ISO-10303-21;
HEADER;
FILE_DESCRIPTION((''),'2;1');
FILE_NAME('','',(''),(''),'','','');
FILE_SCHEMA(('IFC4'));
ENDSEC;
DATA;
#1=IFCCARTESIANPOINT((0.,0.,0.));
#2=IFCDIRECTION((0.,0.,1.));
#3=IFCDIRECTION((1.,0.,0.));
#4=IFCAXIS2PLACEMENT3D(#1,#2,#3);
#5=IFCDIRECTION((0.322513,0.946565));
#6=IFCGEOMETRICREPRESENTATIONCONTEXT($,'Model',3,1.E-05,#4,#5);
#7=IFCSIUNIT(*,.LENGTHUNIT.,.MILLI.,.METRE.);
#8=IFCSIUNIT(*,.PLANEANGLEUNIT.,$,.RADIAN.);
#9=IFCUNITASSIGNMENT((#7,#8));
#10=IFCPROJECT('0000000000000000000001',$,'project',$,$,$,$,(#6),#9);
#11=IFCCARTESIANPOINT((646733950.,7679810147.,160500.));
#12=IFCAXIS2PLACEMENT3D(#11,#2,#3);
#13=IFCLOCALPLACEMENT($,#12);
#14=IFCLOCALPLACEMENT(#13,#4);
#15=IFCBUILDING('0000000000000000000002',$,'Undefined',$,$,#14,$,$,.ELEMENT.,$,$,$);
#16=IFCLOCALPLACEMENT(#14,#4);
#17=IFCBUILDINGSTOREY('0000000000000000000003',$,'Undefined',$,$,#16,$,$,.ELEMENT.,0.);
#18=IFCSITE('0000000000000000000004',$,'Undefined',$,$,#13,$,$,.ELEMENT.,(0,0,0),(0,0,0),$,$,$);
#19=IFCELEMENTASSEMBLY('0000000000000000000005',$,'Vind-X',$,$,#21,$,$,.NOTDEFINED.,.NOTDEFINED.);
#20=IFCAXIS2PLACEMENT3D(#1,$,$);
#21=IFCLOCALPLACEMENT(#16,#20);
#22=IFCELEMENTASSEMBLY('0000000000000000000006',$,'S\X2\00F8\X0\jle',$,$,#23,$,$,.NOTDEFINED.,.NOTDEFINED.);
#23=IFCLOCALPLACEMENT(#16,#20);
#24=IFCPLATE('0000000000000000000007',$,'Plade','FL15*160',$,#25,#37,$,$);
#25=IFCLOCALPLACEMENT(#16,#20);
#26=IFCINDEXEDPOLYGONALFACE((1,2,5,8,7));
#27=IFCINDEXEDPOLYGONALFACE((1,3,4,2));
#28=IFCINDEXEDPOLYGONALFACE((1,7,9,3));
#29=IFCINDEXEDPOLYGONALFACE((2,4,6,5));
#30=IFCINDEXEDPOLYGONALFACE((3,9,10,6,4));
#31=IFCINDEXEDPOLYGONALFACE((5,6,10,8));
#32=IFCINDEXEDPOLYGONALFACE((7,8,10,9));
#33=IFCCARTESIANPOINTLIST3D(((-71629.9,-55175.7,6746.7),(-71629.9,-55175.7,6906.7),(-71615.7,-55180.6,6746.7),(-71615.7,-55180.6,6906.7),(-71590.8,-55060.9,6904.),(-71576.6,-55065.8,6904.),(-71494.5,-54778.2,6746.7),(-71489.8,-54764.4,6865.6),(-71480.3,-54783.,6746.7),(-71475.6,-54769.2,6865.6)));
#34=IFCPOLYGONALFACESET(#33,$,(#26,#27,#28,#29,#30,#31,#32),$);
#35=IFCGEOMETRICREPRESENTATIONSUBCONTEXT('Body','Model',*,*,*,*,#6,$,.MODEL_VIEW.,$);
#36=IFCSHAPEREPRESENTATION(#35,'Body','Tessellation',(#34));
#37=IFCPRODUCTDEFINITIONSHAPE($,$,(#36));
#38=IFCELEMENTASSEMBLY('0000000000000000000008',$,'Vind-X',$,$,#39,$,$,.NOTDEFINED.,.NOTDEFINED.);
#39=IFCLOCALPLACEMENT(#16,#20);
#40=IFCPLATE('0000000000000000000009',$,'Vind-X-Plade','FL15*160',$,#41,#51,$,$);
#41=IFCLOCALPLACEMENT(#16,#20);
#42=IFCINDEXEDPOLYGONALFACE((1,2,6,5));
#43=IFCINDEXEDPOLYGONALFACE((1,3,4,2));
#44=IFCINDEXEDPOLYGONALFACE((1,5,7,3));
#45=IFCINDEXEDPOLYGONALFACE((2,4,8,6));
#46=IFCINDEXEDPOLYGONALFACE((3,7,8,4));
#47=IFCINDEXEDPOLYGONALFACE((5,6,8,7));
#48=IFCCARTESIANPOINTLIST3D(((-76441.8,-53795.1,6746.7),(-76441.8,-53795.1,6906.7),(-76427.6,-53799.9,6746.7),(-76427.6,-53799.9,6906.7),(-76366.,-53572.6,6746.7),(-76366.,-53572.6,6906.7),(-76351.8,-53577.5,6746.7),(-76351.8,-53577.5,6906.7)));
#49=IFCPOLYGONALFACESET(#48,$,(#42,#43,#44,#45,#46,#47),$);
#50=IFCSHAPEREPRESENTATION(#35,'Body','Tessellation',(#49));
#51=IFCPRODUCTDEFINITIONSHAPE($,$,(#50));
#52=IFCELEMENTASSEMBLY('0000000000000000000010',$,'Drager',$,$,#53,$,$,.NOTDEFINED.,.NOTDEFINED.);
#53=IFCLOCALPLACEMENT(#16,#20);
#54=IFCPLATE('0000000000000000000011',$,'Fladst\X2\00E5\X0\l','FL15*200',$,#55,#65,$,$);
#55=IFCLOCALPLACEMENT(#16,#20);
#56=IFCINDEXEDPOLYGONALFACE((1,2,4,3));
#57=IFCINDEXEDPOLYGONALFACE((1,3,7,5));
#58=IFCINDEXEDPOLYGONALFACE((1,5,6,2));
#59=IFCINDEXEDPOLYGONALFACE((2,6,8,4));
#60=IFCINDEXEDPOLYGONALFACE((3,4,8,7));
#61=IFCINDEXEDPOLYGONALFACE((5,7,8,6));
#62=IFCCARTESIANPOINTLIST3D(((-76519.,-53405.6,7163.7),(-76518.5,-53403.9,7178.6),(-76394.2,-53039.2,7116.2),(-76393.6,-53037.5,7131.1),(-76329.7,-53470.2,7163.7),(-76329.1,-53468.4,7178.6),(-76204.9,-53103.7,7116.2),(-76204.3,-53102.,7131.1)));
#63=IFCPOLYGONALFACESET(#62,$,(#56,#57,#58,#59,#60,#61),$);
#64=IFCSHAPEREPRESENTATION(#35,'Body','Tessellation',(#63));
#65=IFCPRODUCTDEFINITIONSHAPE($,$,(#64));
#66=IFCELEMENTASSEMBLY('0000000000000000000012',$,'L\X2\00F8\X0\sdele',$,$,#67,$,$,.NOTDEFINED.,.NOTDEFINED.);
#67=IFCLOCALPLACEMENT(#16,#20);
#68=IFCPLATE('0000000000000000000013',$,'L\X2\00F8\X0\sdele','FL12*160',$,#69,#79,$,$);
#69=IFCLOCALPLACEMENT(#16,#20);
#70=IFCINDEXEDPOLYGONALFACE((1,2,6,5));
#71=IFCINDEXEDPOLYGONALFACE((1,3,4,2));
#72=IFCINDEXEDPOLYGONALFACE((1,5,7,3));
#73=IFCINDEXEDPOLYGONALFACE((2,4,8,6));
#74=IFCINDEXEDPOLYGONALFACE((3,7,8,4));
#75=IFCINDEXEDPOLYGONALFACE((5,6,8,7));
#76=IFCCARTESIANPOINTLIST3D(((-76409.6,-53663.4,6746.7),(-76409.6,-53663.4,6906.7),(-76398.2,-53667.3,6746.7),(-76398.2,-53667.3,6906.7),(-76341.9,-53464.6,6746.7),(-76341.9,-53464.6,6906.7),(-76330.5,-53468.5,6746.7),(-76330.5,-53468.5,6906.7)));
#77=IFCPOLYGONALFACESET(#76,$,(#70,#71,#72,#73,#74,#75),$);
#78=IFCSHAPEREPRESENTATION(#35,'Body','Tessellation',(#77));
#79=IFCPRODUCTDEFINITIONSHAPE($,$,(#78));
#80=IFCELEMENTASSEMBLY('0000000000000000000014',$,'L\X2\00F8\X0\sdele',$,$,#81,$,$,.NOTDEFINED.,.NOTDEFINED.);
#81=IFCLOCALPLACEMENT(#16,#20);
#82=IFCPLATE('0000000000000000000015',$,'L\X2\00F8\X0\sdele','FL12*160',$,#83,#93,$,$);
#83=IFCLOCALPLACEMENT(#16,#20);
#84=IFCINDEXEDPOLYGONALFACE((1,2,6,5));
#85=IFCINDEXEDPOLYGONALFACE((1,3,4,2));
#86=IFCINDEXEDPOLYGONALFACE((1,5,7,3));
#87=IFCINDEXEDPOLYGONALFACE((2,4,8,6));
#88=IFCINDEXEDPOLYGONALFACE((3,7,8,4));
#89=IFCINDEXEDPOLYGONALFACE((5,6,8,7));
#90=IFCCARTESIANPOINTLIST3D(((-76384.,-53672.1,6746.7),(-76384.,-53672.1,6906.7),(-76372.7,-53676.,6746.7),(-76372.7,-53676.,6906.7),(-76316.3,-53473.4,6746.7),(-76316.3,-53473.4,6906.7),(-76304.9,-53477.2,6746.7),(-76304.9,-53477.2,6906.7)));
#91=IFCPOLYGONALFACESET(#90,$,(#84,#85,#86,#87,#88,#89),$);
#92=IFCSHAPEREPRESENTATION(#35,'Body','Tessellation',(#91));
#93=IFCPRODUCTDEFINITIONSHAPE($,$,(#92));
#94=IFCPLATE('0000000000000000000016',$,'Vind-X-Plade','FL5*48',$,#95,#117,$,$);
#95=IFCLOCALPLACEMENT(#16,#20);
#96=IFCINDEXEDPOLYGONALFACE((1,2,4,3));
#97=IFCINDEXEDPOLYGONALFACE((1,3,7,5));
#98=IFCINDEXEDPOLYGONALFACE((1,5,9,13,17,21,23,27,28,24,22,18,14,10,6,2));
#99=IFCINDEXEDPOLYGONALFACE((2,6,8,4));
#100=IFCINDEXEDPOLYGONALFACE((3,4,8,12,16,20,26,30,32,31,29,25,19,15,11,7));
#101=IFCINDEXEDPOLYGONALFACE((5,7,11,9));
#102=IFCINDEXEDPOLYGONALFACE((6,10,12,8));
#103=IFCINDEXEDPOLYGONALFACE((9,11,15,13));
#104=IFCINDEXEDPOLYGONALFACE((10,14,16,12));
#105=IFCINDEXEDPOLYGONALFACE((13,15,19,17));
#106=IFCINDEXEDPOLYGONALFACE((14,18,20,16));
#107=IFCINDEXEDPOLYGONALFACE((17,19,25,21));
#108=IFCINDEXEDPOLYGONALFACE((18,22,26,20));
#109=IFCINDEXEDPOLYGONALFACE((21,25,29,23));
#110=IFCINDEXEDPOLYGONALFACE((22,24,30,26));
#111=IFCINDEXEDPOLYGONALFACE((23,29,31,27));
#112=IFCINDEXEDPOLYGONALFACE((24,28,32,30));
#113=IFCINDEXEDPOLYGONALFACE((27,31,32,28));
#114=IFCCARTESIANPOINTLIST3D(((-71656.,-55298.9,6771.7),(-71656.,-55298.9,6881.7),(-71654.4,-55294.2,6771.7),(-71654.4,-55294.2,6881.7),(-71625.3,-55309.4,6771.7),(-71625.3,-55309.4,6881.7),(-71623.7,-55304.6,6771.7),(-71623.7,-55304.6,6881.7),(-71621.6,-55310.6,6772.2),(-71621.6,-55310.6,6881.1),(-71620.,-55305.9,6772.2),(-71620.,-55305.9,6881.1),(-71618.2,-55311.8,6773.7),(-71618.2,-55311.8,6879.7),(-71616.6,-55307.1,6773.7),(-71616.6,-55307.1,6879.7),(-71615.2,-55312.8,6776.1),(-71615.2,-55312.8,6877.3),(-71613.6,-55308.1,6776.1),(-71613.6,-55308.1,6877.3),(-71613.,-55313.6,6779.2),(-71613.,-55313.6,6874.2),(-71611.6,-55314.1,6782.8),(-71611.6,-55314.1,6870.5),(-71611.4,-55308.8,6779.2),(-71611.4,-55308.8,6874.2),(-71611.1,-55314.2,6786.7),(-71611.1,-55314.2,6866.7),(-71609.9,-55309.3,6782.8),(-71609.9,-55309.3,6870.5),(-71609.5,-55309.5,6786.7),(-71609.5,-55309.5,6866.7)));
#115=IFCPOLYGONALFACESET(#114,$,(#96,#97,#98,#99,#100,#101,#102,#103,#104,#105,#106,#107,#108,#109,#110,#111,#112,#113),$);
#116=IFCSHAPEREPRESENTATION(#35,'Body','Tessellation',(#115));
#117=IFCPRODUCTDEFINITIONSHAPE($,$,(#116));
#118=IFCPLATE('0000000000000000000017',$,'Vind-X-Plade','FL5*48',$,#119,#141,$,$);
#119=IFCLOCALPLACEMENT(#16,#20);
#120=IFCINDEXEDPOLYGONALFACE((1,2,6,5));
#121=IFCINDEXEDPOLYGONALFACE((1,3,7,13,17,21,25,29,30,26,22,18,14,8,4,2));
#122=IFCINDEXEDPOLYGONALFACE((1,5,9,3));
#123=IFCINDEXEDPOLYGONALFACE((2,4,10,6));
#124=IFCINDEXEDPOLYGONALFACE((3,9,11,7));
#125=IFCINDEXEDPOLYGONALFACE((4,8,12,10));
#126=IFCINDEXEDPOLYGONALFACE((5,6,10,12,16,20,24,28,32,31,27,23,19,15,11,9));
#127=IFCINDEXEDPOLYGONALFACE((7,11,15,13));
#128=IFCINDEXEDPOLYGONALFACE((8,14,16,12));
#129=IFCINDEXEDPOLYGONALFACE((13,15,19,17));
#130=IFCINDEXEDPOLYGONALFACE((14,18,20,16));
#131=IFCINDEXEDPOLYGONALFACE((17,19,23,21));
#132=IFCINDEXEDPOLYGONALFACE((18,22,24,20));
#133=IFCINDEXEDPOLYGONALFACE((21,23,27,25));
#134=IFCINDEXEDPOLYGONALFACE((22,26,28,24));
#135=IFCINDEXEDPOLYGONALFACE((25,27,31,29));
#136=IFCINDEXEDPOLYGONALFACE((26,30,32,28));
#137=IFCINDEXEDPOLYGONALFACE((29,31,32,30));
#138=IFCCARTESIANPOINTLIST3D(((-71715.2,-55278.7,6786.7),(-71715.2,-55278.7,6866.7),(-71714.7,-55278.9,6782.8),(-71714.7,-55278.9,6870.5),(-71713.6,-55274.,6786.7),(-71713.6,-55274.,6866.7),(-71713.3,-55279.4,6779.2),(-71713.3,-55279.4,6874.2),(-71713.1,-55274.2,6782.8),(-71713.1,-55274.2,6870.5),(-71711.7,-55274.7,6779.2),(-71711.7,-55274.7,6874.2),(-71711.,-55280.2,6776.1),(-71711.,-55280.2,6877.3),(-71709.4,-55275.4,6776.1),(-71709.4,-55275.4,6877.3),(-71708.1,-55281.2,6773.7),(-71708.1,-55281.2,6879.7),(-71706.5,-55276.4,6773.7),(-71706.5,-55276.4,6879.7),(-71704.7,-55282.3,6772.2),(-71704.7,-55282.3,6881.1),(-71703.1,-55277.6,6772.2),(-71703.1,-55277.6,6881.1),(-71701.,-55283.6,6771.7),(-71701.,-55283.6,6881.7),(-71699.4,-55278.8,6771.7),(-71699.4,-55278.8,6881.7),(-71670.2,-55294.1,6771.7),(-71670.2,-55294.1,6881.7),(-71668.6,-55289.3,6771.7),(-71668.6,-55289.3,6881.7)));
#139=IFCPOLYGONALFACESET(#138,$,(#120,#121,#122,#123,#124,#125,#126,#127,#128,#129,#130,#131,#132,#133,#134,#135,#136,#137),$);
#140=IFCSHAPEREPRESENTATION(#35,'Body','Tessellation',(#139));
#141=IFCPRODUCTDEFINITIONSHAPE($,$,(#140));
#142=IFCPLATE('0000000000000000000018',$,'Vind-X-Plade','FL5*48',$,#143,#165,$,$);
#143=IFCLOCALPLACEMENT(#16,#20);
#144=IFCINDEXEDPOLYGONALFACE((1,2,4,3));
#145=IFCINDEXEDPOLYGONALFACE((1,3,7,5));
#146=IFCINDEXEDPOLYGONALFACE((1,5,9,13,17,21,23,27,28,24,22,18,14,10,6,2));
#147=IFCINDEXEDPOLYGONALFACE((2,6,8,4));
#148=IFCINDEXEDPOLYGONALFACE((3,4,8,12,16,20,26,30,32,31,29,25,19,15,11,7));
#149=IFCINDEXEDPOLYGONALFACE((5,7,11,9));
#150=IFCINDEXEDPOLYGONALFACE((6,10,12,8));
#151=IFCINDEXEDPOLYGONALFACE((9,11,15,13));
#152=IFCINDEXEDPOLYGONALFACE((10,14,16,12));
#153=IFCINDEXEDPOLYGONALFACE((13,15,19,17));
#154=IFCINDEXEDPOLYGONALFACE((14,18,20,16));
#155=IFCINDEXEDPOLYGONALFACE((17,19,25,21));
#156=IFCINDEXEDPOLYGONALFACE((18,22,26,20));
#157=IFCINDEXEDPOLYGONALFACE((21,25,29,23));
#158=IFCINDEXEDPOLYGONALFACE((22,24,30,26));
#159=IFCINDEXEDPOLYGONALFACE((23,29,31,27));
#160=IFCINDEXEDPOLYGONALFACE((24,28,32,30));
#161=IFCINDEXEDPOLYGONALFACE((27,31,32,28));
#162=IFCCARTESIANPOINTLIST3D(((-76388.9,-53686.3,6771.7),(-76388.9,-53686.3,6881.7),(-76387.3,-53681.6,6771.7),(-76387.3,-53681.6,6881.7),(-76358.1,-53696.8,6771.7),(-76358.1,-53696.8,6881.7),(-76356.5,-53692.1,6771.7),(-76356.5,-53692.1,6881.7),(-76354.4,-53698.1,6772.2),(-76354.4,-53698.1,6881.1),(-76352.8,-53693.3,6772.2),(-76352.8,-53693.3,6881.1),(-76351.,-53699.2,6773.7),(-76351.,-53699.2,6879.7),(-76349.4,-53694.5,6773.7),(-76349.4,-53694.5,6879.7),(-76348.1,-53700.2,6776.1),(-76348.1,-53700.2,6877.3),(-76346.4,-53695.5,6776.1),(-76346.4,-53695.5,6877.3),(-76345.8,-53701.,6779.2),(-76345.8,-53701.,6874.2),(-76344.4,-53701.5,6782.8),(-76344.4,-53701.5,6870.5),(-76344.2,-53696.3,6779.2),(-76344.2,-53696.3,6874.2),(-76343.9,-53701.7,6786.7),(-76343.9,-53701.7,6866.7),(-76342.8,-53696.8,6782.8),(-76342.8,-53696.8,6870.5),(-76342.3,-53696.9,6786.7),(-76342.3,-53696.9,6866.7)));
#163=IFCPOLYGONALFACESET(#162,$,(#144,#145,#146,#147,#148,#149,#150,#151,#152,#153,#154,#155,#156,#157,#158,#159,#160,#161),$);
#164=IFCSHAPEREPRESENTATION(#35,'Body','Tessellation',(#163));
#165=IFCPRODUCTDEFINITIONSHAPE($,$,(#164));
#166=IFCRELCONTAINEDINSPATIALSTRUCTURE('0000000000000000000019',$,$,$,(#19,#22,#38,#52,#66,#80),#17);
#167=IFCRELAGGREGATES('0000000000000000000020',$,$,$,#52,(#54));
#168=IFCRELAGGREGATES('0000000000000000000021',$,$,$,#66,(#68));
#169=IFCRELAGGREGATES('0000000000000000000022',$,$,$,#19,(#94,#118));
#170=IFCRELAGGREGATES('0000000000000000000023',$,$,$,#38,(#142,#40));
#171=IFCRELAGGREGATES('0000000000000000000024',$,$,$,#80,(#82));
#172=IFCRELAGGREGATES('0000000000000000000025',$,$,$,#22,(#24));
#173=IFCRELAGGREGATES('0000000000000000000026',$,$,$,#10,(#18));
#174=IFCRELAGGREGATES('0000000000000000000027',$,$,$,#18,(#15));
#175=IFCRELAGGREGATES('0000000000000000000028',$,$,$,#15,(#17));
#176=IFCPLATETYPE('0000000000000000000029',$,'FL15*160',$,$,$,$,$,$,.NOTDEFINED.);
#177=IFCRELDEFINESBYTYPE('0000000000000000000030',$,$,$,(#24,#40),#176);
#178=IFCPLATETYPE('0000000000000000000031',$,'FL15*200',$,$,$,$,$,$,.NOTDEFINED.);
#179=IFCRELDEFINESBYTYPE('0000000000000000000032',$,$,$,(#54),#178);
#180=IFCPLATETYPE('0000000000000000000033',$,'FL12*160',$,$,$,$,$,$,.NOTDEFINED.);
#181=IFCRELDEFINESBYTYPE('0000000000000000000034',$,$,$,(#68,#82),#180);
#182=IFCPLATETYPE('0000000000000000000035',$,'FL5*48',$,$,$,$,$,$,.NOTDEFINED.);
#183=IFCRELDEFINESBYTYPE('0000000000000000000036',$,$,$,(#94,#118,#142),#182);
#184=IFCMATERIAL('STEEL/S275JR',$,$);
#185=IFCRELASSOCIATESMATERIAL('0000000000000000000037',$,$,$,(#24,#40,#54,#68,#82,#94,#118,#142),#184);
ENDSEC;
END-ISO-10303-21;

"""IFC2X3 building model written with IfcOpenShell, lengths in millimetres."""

from ifc_helpers import new_model, si_unit, direction, frame, frame_2d, origin_with_axes, place, context, subcontext, project, spatial, polyline, circle_curve, parameter, trimmed, segment, composite_curve, outline, extrude, material, type_object, element, aggregate, save


model = new_model("IFC2X3")

# Units and contexts
model_context = context("Model", 3, precision=1e-05, world=origin_with_axes(), true_north=direction((0.322513, 0.946565)))
body_context = subcontext(model_context, "Body", "Model", "MODEL_VIEW")
ifc_project = project(units=[si_unit("LENGTHUNIT", "METRE", prefix="MILLI"), si_unit("PLANEANGLEUNIT", "RADIAN")], contexts=[model_context])

# Site, building, storey
site_placement = place(None, frame((646733950.0, 7679810147.0, 160500.0), z_axis=(0.0, 0.0, 1.0), x_axis=(1.0, 0.0, 0.0)))
site = spatial("IfcSite", under=ifc_project, at=site_placement, Name="Undefined", CompositionType="ELEMENT", RefLatitude=(0, 0, 0), RefLongitude=(0, 0, 0))
building_placement = place(site_placement, origin_with_axes())
building = spatial("IfcBuilding", under=site, at=building_placement, Name="Undefined", CompositionType="ELEMENT")
storey_placement = place(building_placement, origin_with_axes())
storey = spatial("IfcBuildingStorey", under=building, at=storey_placement, Name="Undefined", CompositionType="ELEMENT", Elevation=0.0)

# Element assembly
assembly_1_placement = place(storey_placement, origin_with_axes())
assembly_1 = element("IfcElementAssembly", 1, at=assembly_1_placement, inside=storey, Name="Vind-X", AssemblyPlace="NOTDEFINED", PredefinedType="NOTDEFINED")

# Shared definitions
ifc_material_1 = material(Name="STEEL/S275JR")

# Element assemblies, plates
assembly_2_placement = place(storey_placement, origin_with_axes())
assembly_2 = element("IfcElementAssembly", 2, at=assembly_2_placement, inside=storey, Name="Søjle", AssemblyPlace="NOTDEFINED", PredefinedType="NOTDEFINED")
plate_type_1 = type_object("IfcPlateType", Name="FL15*160", PredefinedType="NOTDEFINED")
plate_1_placement = place(assembly_2_placement, frame((-71482.7, -54766.8, 6865.6), z_axis=(-0.946565, 0.322513, 0.0), x_axis=(-0.039304, -0.115357, -0.992546)))
plate_1 = element("IfcPlate", 3, at=plate_1_placement, type_object=plate_type_1, material=ifc_material_1, Name="Plade", Description="FL15*160", context=body_context, shape_type="SweptSolid", body=[
    extrude(outline(polyline([(0.0, 0.0), (119.8, 0.0), (171.0, 416.9), (12.2, 436.4), (0.0, 315.6), (0.0, 0.0)])), frame((0.0, 0.0, -7.5), z_axis=(0.0, 0.0, 1.0), x_axis=(1.0, 0.0, 0.0)), (0.0, 0.0, 1.0), 15.0),
])
assembly_3_placement = place(storey_placement, origin_with_axes())
assembly_3 = element("IfcElementAssembly", 4, at=assembly_3_placement, inside=storey, Name="Vind-X", AssemblyPlace="NOTDEFINED", PredefinedType="NOTDEFINED")
plate_2_placement = place(assembly_3_placement, frame((-76358.9, -53575.1, 6826.7), z_axis=(0.946565, -0.322513, 0.0), x_axis=(-0.322513, -0.946565, 0.0)))
plate_2 = element("IfcPlate", 5, at=plate_2_placement, type_object=plate_type_1, material=ifc_material_1, Name="Vind-X-Plade", Description="FL15*160", context=body_context, shape_type="SweptSolid", body=[
    extrude(outline(polyline([(0.0, -80.0), (0.0, 80.0), (235.0, 80.0), (235.0, -80.0), (0.0, -80.0)])), frame((0.0, 0.0, -7.5), z_axis=(0.0, 0.0, 1.0), x_axis=(1.0, 0.0, 0.0)), (0.0, 0.0, 1.0), 15.0),
])
assembly_4_placement = place(storey_placement, origin_with_axes())
assembly_4 = element("IfcElementAssembly", 6, at=assembly_4_placement, inside=storey, Name="Drager", AssemblyPlace="NOTDEFINED", PredefinedType="NOTDEFINED")
plate_type_2 = type_object("IfcPlateType", Name="FL15*200", PredefinedType="NOTDEFINED")
plate_3_placement = place(assembly_4_placement, frame((-76329.4, -53469.3, 7171.2), z_axis=(0.039304, 0.115357, 0.992546), x_axis=(0.320109, 0.93951, -0.121869)))
plate_3 = element("IfcPlate", 7, at=plate_3_placement, type_object=plate_type_2, material=ifc_material_1, Name="Fladstål", Description="FL15*200", context=body_context, shape_type="SweptSolid", body=[
    extrude(outline(polyline([(0.0, 0.0), (390.0, 0.0), (390.0, 200.0), (0.0, 200.0), (0.0, 0.0)])), frame((0.0, 0.0, -7.5), z_axis=(0.0, 0.0, 1.0), x_axis=(1.0, 0.0, 0.0)), (0.0, 0.0, 1.0), 15.0),
])
aggregate(assembly_4, [plate_3])
assembly_5_placement = place(storey_placement, origin_with_axes())
assembly_5 = element("IfcElementAssembly", 8, at=assembly_5_placement, inside=storey, Name="Løsdele", AssemblyPlace="NOTDEFINED", PredefinedType="NOTDEFINED")
plate_type_3 = type_object("IfcPlateType", Name="FL12*160", PredefinedType="NOTDEFINED")
plate_4_placement = place(assembly_5_placement, frame((-76336.2, -53466.6, 6826.7), z_axis=(-0.946565, 0.322513, 0.0), x_axis=(-0.322513, -0.946565, 0.0)))
plate_4 = element("IfcPlate", 9, at=plate_4_placement, type_object=plate_type_3, material=ifc_material_1, Name="Løsdele", Description="FL12*160", context=body_context, shape_type="SweptSolid", body=[
    extrude(outline(polyline([(0.0, -80.0), (0.0, 80.0), (210.0, 80.0), (210.0, -80.0), (0.0, -80.0)])), frame((0.0, 0.0, -6.0), z_axis=(0.0, 0.0, 1.0), x_axis=(1.0, 0.0, 0.0)), (0.0, 0.0, 1.0), 12.0),
])
aggregate(assembly_5, [plate_4])
assembly_6_placement = place(storey_placement, origin_with_axes())
assembly_6 = element("IfcElementAssembly", 10, at=assembly_6_placement, inside=storey, Name="Løsdele", AssemblyPlace="NOTDEFINED", PredefinedType="NOTDEFINED")
plate_5_placement = place(assembly_6_placement, frame((-76310.6, -53475.3, 6826.7), z_axis=(-0.946565, 0.322513, 0.0), x_axis=(-0.322513, -0.946565, 0.0)))
plate_5 = element("IfcPlate", 11, at=plate_5_placement, type_object=plate_type_3, material=ifc_material_1, Name="Løsdele", Description="FL12*160", context=body_context, shape_type="SweptSolid", body=[
    extrude(outline(polyline([(0.0, -80.0), (0.0, 80.0), (210.0, 80.0), (210.0, -80.0), (0.0, -80.0)])), frame((0.0, 0.0, -6.0), z_axis=(0.0, 0.0, 1.0), x_axis=(1.0, 0.0, 0.0)), (0.0, 0.0, 1.0), 12.0),
])

# Plates
plate_type_4 = type_object("IfcPlateType", Name="FL5*48", PredefinedType="NOTDEFINED")
plate_6_placement = place(assembly_1_placement, frame((-71610.3, -55311.9, 6881.7), z_axis=(-0.322513, -0.946565, 0.0), x_axis=(-0.946565, 0.322513, 0.0)))
plate_6 = element("IfcPlate", 12, at=plate_6_placement, type_object=plate_type_4, material=ifc_material_1, Name="Vind-X-Plade", Description="FL5*48", context=body_context, shape_type="SweptSolid", body=[
    extrude(outline(composite_curve([segment(trimmed(circle_curve(frame_2d((15.0, 15.0), x_axis=(-1.0, 0.0)), 15.0), [parameter(0.0)], [parameter(1.570796)], True, "PARAMETER"), True, "CONTINUOUS"), segment(polyline([(15.0, 0.0), (47.5, 0.0), (47.5, 110.0), (15.0, 110.0)]), True, "CONTINUOUS"), segment(trimmed(circle_curve(frame_2d((15.0, 95.0), x_axis=(0.0, 1.0)), 15.0), [parameter(0.0)], [parameter(1.570796)], True, "PARAMETER"), True, "CONTINUOUS"), segment(polyline([(0.0, 95.0), (0.0, 15.0)]), True, "CONTINUOUS")], self_intersect=True)), frame((0.0, 0.0, -2.5), z_axis=(0.0, 0.0, 1.0), x_axis=(1.0, 0.0, 0.0)), (0.0, 0.0, 1.0), 5.0),
])
plate_7_placement = place(assembly_1_placement, frame((-71669.4, -55291.7, 6881.7), z_axis=(-0.322513, -0.946565, 0.0), x_axis=(-0.946565, 0.322513, 0.0)))
plate_7 = element("IfcPlate", 13, at=plate_7_placement, type_object=plate_type_4, material=ifc_material_1, Name="Vind-X-Plade", Description="FL5*48", context=body_context, shape_type="SweptSolid", body=[
    extrude(outline(composite_curve([segment(polyline([(0.0, 0.0), (32.5, 0.0)]), True, "CONTINUOUS"), segment(trimmed(circle_curve(frame_2d((32.5, 15.0), x_axis=(0.0, -1.0)), 15.0), [parameter(0.0)], [parameter(1.570796)], True, "PARAMETER"), True, "CONTINUOUS"), segment(polyline([(47.5, 15.0), (47.5, 95.0)]), True, "CONTINUOUS"), segment(trimmed(circle_curve(frame_2d((32.5, 95.0), x_axis=(1.0, 0.0)), 15.0), [parameter(0.0)], [parameter(1.570796)], True, "PARAMETER"), True, "CONTINUOUS"), segment(polyline([(32.5, 110.0), (0.0, 110.0), (0.0, 0.0)]), True, "CONTINUOUS")], self_intersect=True)), frame((0.0, 0.0, -2.5), z_axis=(0.0, 0.0, 1.0), x_axis=(1.0, 0.0, 0.0)), (0.0, 0.0, 1.0), 5.0),
])
aggregate(assembly_1, [plate_6, plate_7])
plate_8_placement = place(assembly_3_placement, frame((-76343.1, -53699.3, 6881.7), z_axis=(-0.322513, -0.946565, 0.0), x_axis=(-0.946565, 0.322513, 0.0)))
plate_8 = element("IfcPlate", 14, at=plate_8_placement, type_object=plate_type_4, material=ifc_material_1, Name="Vind-X-Plade", Description="FL5*48", context=body_context, shape_type="SweptSolid", body=[
    extrude(outline(composite_curve([segment(trimmed(circle_curve(frame_2d((15.0, 15.0), x_axis=(-1.0, 0.0)), 15.0), [parameter(0.0)], [parameter(1.570796)], True, "PARAMETER"), True, "CONTINUOUS"), segment(polyline([(15.0, 0.0), (47.5, 0.0), (47.5, 110.0), (15.0, 110.0)]), True, "CONTINUOUS"), segment(trimmed(circle_curve(frame_2d((15.0, 95.0), x_axis=(0.0, 1.0)), 15.0), [parameter(0.0)], [parameter(1.570796)], True, "PARAMETER"), True, "CONTINUOUS"), segment(polyline([(0.0, 95.0), (0.0, 15.0)]), True, "CONTINUOUS")], self_intersect=True)), frame((0.0, 0.0, -2.5), z_axis=(0.0, 0.0, 1.0), x_axis=(1.0, 0.0, 0.0)), (0.0, 0.0, 1.0), 5.0),
])
aggregate(assembly_3, [plate_8, plate_2])

aggregate(assembly_6, [plate_5])
aggregate(assembly_2, [plate_1])

save(model, "model.ifc")
